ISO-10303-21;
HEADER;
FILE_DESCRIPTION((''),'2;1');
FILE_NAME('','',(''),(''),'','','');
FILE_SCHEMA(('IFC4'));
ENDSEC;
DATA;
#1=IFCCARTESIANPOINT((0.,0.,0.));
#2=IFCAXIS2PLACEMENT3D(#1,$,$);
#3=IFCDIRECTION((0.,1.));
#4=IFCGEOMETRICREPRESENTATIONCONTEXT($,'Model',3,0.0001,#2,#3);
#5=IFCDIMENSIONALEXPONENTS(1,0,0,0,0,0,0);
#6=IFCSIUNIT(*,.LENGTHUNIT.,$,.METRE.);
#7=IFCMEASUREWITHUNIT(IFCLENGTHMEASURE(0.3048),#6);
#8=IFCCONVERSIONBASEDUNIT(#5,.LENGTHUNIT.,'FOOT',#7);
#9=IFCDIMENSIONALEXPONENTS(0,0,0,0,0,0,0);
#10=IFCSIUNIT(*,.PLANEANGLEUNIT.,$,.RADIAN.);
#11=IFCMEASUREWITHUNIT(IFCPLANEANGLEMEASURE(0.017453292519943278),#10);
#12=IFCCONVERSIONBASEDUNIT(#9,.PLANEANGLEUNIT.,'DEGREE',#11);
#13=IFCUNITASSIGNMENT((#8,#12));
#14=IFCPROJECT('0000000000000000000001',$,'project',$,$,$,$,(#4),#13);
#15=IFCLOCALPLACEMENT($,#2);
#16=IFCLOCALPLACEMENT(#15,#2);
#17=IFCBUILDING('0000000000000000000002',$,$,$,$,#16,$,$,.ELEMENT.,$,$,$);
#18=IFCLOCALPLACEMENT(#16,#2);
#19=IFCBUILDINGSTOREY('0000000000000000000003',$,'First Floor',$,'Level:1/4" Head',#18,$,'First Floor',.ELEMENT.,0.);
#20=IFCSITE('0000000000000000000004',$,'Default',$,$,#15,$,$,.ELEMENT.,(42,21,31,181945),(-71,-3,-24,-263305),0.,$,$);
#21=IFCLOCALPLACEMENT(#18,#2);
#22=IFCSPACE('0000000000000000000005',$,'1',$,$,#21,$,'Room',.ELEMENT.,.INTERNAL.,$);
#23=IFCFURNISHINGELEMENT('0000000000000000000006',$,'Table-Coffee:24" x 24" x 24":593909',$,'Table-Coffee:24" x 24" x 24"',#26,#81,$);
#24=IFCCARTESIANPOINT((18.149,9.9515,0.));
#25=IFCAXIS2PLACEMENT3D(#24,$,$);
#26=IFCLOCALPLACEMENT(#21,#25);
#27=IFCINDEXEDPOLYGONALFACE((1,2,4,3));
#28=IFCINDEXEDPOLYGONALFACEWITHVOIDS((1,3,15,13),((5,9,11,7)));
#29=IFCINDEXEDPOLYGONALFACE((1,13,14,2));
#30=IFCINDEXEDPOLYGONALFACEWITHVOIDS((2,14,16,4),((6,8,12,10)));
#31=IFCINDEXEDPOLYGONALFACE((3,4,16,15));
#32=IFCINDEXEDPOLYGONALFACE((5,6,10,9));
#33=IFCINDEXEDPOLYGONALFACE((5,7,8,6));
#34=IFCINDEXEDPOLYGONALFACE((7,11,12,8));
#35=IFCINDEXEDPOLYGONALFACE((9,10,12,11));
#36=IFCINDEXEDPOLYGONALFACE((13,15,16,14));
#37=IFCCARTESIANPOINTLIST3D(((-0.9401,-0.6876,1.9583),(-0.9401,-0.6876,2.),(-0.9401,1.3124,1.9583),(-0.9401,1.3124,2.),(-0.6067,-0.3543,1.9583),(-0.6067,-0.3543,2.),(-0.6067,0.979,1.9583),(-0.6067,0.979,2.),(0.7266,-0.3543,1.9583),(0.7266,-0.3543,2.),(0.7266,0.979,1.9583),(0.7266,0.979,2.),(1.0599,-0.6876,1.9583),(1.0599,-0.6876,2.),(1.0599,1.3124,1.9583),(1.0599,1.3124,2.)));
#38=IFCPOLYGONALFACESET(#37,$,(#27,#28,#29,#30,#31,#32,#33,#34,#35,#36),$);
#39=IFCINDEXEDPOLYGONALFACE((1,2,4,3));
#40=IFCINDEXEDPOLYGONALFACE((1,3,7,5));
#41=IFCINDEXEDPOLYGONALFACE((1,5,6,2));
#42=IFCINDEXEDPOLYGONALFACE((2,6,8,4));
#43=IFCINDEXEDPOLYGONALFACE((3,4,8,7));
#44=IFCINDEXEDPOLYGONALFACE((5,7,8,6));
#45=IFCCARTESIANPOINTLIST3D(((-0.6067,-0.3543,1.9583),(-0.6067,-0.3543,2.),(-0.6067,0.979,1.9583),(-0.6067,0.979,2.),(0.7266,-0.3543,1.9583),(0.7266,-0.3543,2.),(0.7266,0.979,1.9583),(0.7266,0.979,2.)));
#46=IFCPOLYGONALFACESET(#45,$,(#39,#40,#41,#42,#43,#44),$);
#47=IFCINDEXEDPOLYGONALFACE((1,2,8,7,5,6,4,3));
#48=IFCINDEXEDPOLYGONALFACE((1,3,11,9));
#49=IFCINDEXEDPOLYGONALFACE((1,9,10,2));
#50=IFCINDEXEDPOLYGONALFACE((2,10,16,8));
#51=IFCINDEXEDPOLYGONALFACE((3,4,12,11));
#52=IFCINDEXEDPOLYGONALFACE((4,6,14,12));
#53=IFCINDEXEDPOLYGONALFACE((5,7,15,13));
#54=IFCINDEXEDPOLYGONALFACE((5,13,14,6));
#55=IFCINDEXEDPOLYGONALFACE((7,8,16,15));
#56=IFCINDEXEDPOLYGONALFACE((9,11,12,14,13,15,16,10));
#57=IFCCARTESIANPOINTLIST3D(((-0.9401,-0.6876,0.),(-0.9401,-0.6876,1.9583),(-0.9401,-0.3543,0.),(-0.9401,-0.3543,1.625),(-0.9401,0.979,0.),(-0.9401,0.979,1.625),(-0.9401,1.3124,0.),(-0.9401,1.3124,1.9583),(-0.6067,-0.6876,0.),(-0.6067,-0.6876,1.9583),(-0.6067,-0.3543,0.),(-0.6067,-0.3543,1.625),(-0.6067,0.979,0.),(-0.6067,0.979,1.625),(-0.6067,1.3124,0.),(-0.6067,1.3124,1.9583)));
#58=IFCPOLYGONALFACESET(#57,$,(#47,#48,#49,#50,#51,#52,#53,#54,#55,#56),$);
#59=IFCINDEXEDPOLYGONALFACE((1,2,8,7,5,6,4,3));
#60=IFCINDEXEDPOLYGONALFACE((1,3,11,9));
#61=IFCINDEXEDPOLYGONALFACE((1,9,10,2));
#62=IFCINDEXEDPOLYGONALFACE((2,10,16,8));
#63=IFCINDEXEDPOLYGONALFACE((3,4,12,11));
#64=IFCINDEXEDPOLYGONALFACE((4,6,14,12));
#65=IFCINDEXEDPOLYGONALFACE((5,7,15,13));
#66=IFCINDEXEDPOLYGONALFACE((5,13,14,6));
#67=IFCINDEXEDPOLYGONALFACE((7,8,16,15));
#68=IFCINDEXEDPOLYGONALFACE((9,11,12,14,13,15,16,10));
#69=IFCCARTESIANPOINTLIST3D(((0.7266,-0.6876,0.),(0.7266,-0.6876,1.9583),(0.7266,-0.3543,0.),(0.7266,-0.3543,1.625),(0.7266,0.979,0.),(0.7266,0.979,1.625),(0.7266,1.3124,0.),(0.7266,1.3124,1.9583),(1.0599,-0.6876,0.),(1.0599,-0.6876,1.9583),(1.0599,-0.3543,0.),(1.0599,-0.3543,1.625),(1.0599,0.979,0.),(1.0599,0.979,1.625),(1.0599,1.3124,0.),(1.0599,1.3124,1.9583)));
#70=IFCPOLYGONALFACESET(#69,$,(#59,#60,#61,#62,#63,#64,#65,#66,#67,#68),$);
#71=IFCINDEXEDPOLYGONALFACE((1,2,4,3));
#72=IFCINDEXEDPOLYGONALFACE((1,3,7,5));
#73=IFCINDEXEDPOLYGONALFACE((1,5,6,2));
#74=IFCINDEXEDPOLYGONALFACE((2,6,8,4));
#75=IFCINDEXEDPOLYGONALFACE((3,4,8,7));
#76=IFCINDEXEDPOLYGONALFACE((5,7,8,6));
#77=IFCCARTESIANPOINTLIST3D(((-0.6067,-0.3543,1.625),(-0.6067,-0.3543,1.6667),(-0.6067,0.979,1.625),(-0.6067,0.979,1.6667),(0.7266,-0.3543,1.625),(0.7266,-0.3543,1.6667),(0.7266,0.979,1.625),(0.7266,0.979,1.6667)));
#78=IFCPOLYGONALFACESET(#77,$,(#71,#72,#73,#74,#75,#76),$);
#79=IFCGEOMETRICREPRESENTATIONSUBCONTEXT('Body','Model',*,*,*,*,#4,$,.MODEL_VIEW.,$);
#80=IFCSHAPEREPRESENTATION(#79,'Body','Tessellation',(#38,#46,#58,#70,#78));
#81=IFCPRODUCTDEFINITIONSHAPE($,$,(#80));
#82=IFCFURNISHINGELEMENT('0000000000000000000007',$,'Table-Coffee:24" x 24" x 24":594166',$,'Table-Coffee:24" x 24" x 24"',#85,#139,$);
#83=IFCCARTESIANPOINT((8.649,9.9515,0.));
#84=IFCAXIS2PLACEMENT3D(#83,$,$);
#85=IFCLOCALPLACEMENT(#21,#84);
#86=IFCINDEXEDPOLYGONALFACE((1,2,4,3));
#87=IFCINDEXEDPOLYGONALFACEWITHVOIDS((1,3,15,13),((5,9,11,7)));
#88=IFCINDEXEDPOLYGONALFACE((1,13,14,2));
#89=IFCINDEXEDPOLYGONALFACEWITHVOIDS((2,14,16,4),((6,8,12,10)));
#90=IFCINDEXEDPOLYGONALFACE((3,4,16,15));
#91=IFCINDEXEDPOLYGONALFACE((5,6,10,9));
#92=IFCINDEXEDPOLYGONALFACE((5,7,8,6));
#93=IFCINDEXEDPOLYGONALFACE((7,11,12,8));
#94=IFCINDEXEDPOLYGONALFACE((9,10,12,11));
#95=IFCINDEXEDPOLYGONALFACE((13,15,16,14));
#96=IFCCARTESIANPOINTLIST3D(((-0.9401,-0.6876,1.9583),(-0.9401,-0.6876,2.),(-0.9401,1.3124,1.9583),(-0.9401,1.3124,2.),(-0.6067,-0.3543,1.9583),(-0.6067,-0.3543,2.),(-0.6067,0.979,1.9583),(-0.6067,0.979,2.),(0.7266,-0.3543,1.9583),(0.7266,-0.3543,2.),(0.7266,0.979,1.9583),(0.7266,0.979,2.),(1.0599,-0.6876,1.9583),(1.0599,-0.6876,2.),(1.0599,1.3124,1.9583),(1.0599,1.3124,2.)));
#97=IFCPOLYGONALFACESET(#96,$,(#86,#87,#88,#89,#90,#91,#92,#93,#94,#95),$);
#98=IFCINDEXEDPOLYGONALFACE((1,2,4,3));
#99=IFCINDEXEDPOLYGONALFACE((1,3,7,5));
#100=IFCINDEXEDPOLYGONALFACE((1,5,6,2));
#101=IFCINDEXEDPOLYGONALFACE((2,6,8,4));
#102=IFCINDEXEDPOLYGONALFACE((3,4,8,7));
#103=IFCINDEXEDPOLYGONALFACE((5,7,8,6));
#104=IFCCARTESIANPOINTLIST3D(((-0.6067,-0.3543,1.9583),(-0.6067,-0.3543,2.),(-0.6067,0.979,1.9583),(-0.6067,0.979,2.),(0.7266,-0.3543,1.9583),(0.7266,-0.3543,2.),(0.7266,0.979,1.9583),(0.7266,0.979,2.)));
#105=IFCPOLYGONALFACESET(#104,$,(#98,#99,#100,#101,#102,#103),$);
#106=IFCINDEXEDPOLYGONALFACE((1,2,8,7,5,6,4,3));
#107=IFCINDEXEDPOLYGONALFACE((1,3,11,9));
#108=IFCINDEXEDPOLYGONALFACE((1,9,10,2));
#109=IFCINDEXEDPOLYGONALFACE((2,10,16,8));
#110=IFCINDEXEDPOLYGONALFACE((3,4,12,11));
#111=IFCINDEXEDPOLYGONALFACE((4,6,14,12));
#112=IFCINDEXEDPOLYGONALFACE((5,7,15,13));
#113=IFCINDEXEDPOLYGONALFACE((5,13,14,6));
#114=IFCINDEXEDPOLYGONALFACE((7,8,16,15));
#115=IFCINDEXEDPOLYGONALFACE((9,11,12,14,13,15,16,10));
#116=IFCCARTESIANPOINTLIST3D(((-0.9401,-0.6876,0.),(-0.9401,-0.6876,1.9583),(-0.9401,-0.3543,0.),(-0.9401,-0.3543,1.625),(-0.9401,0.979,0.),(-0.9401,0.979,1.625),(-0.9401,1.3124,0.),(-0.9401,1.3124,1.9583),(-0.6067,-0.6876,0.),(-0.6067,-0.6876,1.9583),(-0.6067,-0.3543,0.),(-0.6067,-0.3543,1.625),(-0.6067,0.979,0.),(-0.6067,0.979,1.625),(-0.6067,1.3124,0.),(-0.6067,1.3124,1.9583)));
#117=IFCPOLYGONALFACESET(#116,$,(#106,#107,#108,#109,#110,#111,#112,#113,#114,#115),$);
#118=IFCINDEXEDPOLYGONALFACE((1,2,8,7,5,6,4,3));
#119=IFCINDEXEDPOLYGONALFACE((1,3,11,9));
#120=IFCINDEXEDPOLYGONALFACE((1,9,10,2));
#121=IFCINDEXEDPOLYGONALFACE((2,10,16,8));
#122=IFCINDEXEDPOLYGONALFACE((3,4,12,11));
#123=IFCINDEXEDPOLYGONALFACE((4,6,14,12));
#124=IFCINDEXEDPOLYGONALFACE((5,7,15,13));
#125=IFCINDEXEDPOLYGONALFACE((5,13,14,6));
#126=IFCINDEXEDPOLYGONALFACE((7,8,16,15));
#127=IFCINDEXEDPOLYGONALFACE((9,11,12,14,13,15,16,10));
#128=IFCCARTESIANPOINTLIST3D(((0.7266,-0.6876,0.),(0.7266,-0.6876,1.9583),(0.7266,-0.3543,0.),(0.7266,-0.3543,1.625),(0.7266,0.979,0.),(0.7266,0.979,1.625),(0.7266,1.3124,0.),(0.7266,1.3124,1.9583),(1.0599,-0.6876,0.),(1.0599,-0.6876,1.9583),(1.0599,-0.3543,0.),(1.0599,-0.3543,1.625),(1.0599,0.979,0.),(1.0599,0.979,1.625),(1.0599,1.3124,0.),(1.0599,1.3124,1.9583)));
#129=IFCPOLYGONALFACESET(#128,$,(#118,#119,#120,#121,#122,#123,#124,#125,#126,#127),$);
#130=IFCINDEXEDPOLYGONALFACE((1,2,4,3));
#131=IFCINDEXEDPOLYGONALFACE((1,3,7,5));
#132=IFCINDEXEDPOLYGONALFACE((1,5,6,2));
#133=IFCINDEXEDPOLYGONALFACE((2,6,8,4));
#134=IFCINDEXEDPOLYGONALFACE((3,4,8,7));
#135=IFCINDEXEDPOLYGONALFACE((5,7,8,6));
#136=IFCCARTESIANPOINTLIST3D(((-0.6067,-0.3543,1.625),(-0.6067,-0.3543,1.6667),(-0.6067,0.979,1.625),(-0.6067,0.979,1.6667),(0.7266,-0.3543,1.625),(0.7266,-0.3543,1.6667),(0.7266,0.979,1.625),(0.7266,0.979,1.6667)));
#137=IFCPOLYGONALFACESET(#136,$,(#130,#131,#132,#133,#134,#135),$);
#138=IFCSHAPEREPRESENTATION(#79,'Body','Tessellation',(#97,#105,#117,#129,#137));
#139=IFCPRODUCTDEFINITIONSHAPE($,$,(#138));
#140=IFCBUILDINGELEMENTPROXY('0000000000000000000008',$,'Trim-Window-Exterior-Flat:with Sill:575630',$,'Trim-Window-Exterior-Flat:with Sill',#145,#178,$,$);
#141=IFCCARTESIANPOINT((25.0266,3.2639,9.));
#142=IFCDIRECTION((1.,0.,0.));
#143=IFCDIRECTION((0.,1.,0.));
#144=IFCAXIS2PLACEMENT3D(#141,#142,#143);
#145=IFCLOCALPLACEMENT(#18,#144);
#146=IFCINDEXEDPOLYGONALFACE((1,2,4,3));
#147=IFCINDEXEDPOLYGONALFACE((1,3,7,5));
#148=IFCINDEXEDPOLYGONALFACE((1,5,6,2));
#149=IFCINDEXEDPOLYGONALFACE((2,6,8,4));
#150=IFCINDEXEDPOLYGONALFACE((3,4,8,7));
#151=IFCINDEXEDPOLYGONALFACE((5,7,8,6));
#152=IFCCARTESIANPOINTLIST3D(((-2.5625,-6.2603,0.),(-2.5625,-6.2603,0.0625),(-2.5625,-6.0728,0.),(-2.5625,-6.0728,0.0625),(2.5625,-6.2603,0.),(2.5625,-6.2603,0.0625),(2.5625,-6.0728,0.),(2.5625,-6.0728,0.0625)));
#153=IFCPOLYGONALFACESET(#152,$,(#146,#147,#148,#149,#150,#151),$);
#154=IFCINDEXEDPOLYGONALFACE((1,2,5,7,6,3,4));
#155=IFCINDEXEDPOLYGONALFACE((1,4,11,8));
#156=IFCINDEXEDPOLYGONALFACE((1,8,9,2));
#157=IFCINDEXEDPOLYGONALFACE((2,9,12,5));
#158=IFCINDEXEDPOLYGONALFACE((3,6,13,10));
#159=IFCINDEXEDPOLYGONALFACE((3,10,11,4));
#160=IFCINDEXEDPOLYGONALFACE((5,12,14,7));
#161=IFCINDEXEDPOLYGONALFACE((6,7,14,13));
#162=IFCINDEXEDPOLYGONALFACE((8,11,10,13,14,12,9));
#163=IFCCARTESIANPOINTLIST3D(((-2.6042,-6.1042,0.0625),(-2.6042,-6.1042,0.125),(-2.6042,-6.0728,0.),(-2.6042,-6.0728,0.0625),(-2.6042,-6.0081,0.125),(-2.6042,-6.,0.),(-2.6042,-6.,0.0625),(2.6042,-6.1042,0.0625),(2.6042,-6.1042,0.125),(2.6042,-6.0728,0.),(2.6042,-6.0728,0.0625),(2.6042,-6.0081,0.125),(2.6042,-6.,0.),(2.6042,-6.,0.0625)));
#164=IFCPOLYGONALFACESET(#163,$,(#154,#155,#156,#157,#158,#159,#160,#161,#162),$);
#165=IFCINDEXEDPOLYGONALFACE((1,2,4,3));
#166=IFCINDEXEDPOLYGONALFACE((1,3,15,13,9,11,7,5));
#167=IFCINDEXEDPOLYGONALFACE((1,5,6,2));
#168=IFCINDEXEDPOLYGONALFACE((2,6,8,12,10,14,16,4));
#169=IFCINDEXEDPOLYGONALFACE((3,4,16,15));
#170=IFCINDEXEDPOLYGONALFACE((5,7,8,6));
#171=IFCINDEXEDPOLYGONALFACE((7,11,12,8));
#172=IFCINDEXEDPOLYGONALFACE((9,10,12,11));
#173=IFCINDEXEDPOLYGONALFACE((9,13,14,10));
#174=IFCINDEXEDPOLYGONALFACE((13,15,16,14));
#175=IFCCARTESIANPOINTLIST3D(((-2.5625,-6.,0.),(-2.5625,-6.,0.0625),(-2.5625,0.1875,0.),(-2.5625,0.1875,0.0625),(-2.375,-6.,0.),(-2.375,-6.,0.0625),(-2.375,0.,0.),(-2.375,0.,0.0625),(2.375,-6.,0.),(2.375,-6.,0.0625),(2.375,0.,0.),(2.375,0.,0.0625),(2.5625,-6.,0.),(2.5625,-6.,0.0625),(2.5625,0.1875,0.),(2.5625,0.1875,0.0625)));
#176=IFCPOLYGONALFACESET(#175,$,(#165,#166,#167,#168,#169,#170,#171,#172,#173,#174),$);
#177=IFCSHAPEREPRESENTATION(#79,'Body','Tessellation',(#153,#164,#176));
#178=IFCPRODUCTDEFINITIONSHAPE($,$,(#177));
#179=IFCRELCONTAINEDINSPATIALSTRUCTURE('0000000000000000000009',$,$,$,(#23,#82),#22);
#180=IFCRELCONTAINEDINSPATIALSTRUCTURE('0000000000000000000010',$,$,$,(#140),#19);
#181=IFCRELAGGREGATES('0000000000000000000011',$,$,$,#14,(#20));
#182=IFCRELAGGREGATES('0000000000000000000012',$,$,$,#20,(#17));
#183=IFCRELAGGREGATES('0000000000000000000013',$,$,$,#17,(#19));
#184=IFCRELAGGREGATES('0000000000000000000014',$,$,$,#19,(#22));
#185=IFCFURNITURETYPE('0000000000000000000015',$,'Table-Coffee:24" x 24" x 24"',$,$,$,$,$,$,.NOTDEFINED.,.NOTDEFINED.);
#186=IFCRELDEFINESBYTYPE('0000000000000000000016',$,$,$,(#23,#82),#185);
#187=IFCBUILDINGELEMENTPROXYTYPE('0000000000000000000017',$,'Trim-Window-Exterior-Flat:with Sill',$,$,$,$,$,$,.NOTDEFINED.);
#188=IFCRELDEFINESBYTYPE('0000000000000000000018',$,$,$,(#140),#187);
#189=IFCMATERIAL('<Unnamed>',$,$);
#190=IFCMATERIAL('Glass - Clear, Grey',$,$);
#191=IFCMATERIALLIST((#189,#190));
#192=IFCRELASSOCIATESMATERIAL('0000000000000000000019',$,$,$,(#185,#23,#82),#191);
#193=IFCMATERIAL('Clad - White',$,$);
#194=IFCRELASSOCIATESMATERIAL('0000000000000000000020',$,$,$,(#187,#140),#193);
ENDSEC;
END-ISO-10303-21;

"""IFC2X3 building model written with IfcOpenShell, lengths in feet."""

from ifc_helpers import new_model, entity, si_unit, converted_unit, direction, frame, frame_2d, origin, origin_2d_with_axis, place, context, subcontext, project, spatial, polyline, rectangle, outline, extrude, source, transform, mapped, material, material_list, type_object, type_shapes, element, save


model = new_model("IFC2X3")

# Units and contexts
model_context = context("Model", 3, precision=0.0001, world=origin(), true_north=direction((0.0, 1.0)))
body_context = subcontext(model_context, "Body", "Model", "MODEL_VIEW")
ifc_project = project(units=[converted_unit("LENGTHUNIT", "FOOT", entity("IfcLengthMeasure", 0.3048), si_unit("LENGTHUNIT", "METRE"), dimensions=[1, 0, 0, 0, 0, 0, 0]), converted_unit("PLANEANGLEUNIT", "DEGREE", entity("IfcPlaneAngleMeasure", 0.017453292519943278), si_unit("PLANEANGLEUNIT", "RADIAN"), dimensions=[0, 0, 0, 0, 0, 0, 0])], contexts=[model_context])

# Site, building, storey
site_placement = place(None, origin())
site = spatial("IfcSite", under=ifc_project, at=site_placement, Name="Default", CompositionType="ELEMENT", RefLatitude=(42, 21, 31, 181945), RefLongitude=(-71, -3, -24, -263305), RefElevation=0.0)
building_placement = place(site_placement, origin())
building = spatial("IfcBuilding", under=site, at=building_placement, CompositionType="ELEMENT")
storey_placement = place(building_placement, origin())
storey = spatial("IfcBuildingStorey", under=building, at=storey_placement, Name="First Floor", ObjectType="Level:1/4\" Head", LongName="First Floor", CompositionType="ELEMENT", Elevation=0.0)

# Shared definitions
space_placement = place(storey_placement, origin())
space = spatial("IfcSpace", under=storey, at=space_placement, Name="1", LongName="Room", CompositionType="ELEMENT", InteriorOrExteriorSpace="INTERNAL")

# Furnishing elements
ifc_material_1 = material(Name="<Unnamed>")
ifc_material_2 = material(Name="Glass - Clear, Grey")
ifc_material_list_1 = material_list([ifc_material_1, ifc_material_2])
furniture_type_1 = type_object("IfcFurnitureType", Name="Table-Coffee:24\" x 24\" x 24\"", AssemblyPlace="NOTDEFINED", material=ifc_material_list_1)
shared_shape_1 = source(origin(), body_context, "Body", "SweptSolid", [
    extrude(outline(polyline([(-1.0, -1.0), (1.0, -1.0), (1.0, 1.0), (-1.0, 1.0), (-1.0, -1.0)]), holes=[polyline([(-0.6667, -0.6667), (-0.6667, 0.6667), (0.6667, 0.6667), (0.6667, -0.6667), (-0.6667, -0.6667)])]), frame((0.0599, 0.3124, 1.9583), z_axis=(0.0, 0.0, 1.0), x_axis=(-1.0, 0.0, 0.0)), (0.0, 0.0, 1.0), 0.0417),
    extrude(rectangle(XDim=1.3333, YDim=1.3333, at=origin_2d_with_axis()), frame((0.0599, 0.3124, 1.9583), z_axis=(0.0, 0.0, 1.0), x_axis=(-1.0, 0.0, 0.0)), (0.0, 0.0, 1.0), 0.0417),
    extrude(outline(polyline([(-1.0, -1.0625), (1.0, -1.0625), (1.0, 0.8958), (0.6667, 0.8958), (0.6667, -0.7292), (-0.6667, -0.7292), (-0.6667, 0.8958), (-1.0, 0.8958), (-1.0, -1.0625)])), frame((-0.9401, 0.3124, 0.8958), z_axis=(1.0, 0.0, 0.0), x_axis=(0.0, -1.0, 0.0)), (0.0, 0.0, 1.0), 0.3333),
    extrude(outline(polyline([(-0.8958, -1.0), (1.0625, -1.0), (1.0625, 1.0), (-0.8958, 1.0), (-0.8958, 0.6667), (0.7292, 0.6667), (0.7292, -0.6667), (-0.8958, -0.6667), (-0.8958, -1.0)])), frame((0.7266, 0.3124, 0.8958), z_axis=(1.0, 0.0, 0.0), x_axis=(0.0, 0.0, 1.0)), (0.0, 0.0, 1.0), 0.3333),
    extrude(rectangle(XDim=1.3333, YDim=1.3333, at=origin_2d_with_axis()), frame((0.0599, 0.3124, 1.625), z_axis=(0.0, 0.0, 1.0), x_axis=(-1.0, 0.0, 0.0)), (0.0, 0.0, 1.0), 0.0417),
])
type_shapes(furniture_type_1, [shared_shape_1])
for number, where, name in (
    (1, (18.149, 9.9515, 0.0), "Table-Coffee:24\" x 24\" x 24\":593909"),
    (2, (8.649, 9.9515, 0.0), "Table-Coffee:24\" x 24\" x 24\":594166"),
):
    element("IfcFurnishingElement", number, at=place(space_placement, frame(where)), inside=space, type_object=furniture_type_1, material=ifc_material_list_1, Name=name, ObjectType="Table-Coffee:24\" x 24\" x 24\"", context=body_context, shape_type="MappedRepresentation", body=[
        mapped(shared_shape_1, transform((0.0, 0.0, 0.0), scale=1.0)),
    ])

# Building element proxy
ifc_material_3 = material(Name="Clad - White")
building_element_proxy_type_1 = type_object("IfcBuildingElementProxyType", Name="Trim-Window-Exterior-Flat:with Sill", PredefinedType="NOTDEFINED", material=ifc_material_3)
shared_shape_2 = source(origin(), body_context, "Body", "SweptSolid", [
    extrude(rectangle(XDim=5.125, YDim=0.1875, at=frame_2d((0.0, 0.0), x_axis=(1.0, 0.0))), frame((0.0, -6.1665, 0.0), z_axis=(0.0, 0.0, 1.0), x_axis=(-1.0, 0.0, 0.0)), (0.0, 0.0, 1.0), 0.0625),
    extrude(outline(polyline([(-0.0625, -0.0525), (0.0, -0.0525), (0.0, -0.0211), (0.0625, -0.0211), (0.0625, 0.0517), (0.0, 0.0517), (-0.0625, 0.0436), (-0.0625, -0.0525)])), frame((-2.6042, -6.0517, 0.0625), z_axis=(1.0, 0.0, 0.0), x_axis=(0.0, 0.0, -1.0)), (0.0, 0.0, 1.0), 5.2083),
    extrude(outline(polyline([(-3.1406, -2.5625), (3.0469, -2.5625), (3.0469, -2.375), (-2.9531, -2.375), (-2.9531, 2.375), (3.0469, 2.375), (3.0469, 2.5625), (-3.1406, 2.5625), (-3.1406, -2.5625)])), frame((0.0, -2.9531, 0.0), z_axis=(0.0, 0.0, 1.0), x_axis=(0.0, -1.0, 0.0)), (0.0, 0.0, 1.0), 0.0625),
])
type_shapes(building_element_proxy_type_1, [shared_shape_2])
proxy_1_placement = place(storey_placement, frame((25.0266, 3.2639, 9.0), z_axis=(1.0, 0.0, 0.0), x_axis=(0.0, 1.0, 0.0)))
element("IfcBuildingElementProxy", 3, at=proxy_1_placement, inside=storey, type_object=building_element_proxy_type_1, material=ifc_material_3, Name="Trim-Window-Exterior-Flat:with Sill:575630", ObjectType="Trim-Window-Exterior-Flat:with Sill", context=body_context, shape_type="MappedRepresentation", body=[
    mapped(shared_shape_2, transform((0.0, 0.0, 0.0), scale=1.0)),
])

save(model, "model.ifc")
